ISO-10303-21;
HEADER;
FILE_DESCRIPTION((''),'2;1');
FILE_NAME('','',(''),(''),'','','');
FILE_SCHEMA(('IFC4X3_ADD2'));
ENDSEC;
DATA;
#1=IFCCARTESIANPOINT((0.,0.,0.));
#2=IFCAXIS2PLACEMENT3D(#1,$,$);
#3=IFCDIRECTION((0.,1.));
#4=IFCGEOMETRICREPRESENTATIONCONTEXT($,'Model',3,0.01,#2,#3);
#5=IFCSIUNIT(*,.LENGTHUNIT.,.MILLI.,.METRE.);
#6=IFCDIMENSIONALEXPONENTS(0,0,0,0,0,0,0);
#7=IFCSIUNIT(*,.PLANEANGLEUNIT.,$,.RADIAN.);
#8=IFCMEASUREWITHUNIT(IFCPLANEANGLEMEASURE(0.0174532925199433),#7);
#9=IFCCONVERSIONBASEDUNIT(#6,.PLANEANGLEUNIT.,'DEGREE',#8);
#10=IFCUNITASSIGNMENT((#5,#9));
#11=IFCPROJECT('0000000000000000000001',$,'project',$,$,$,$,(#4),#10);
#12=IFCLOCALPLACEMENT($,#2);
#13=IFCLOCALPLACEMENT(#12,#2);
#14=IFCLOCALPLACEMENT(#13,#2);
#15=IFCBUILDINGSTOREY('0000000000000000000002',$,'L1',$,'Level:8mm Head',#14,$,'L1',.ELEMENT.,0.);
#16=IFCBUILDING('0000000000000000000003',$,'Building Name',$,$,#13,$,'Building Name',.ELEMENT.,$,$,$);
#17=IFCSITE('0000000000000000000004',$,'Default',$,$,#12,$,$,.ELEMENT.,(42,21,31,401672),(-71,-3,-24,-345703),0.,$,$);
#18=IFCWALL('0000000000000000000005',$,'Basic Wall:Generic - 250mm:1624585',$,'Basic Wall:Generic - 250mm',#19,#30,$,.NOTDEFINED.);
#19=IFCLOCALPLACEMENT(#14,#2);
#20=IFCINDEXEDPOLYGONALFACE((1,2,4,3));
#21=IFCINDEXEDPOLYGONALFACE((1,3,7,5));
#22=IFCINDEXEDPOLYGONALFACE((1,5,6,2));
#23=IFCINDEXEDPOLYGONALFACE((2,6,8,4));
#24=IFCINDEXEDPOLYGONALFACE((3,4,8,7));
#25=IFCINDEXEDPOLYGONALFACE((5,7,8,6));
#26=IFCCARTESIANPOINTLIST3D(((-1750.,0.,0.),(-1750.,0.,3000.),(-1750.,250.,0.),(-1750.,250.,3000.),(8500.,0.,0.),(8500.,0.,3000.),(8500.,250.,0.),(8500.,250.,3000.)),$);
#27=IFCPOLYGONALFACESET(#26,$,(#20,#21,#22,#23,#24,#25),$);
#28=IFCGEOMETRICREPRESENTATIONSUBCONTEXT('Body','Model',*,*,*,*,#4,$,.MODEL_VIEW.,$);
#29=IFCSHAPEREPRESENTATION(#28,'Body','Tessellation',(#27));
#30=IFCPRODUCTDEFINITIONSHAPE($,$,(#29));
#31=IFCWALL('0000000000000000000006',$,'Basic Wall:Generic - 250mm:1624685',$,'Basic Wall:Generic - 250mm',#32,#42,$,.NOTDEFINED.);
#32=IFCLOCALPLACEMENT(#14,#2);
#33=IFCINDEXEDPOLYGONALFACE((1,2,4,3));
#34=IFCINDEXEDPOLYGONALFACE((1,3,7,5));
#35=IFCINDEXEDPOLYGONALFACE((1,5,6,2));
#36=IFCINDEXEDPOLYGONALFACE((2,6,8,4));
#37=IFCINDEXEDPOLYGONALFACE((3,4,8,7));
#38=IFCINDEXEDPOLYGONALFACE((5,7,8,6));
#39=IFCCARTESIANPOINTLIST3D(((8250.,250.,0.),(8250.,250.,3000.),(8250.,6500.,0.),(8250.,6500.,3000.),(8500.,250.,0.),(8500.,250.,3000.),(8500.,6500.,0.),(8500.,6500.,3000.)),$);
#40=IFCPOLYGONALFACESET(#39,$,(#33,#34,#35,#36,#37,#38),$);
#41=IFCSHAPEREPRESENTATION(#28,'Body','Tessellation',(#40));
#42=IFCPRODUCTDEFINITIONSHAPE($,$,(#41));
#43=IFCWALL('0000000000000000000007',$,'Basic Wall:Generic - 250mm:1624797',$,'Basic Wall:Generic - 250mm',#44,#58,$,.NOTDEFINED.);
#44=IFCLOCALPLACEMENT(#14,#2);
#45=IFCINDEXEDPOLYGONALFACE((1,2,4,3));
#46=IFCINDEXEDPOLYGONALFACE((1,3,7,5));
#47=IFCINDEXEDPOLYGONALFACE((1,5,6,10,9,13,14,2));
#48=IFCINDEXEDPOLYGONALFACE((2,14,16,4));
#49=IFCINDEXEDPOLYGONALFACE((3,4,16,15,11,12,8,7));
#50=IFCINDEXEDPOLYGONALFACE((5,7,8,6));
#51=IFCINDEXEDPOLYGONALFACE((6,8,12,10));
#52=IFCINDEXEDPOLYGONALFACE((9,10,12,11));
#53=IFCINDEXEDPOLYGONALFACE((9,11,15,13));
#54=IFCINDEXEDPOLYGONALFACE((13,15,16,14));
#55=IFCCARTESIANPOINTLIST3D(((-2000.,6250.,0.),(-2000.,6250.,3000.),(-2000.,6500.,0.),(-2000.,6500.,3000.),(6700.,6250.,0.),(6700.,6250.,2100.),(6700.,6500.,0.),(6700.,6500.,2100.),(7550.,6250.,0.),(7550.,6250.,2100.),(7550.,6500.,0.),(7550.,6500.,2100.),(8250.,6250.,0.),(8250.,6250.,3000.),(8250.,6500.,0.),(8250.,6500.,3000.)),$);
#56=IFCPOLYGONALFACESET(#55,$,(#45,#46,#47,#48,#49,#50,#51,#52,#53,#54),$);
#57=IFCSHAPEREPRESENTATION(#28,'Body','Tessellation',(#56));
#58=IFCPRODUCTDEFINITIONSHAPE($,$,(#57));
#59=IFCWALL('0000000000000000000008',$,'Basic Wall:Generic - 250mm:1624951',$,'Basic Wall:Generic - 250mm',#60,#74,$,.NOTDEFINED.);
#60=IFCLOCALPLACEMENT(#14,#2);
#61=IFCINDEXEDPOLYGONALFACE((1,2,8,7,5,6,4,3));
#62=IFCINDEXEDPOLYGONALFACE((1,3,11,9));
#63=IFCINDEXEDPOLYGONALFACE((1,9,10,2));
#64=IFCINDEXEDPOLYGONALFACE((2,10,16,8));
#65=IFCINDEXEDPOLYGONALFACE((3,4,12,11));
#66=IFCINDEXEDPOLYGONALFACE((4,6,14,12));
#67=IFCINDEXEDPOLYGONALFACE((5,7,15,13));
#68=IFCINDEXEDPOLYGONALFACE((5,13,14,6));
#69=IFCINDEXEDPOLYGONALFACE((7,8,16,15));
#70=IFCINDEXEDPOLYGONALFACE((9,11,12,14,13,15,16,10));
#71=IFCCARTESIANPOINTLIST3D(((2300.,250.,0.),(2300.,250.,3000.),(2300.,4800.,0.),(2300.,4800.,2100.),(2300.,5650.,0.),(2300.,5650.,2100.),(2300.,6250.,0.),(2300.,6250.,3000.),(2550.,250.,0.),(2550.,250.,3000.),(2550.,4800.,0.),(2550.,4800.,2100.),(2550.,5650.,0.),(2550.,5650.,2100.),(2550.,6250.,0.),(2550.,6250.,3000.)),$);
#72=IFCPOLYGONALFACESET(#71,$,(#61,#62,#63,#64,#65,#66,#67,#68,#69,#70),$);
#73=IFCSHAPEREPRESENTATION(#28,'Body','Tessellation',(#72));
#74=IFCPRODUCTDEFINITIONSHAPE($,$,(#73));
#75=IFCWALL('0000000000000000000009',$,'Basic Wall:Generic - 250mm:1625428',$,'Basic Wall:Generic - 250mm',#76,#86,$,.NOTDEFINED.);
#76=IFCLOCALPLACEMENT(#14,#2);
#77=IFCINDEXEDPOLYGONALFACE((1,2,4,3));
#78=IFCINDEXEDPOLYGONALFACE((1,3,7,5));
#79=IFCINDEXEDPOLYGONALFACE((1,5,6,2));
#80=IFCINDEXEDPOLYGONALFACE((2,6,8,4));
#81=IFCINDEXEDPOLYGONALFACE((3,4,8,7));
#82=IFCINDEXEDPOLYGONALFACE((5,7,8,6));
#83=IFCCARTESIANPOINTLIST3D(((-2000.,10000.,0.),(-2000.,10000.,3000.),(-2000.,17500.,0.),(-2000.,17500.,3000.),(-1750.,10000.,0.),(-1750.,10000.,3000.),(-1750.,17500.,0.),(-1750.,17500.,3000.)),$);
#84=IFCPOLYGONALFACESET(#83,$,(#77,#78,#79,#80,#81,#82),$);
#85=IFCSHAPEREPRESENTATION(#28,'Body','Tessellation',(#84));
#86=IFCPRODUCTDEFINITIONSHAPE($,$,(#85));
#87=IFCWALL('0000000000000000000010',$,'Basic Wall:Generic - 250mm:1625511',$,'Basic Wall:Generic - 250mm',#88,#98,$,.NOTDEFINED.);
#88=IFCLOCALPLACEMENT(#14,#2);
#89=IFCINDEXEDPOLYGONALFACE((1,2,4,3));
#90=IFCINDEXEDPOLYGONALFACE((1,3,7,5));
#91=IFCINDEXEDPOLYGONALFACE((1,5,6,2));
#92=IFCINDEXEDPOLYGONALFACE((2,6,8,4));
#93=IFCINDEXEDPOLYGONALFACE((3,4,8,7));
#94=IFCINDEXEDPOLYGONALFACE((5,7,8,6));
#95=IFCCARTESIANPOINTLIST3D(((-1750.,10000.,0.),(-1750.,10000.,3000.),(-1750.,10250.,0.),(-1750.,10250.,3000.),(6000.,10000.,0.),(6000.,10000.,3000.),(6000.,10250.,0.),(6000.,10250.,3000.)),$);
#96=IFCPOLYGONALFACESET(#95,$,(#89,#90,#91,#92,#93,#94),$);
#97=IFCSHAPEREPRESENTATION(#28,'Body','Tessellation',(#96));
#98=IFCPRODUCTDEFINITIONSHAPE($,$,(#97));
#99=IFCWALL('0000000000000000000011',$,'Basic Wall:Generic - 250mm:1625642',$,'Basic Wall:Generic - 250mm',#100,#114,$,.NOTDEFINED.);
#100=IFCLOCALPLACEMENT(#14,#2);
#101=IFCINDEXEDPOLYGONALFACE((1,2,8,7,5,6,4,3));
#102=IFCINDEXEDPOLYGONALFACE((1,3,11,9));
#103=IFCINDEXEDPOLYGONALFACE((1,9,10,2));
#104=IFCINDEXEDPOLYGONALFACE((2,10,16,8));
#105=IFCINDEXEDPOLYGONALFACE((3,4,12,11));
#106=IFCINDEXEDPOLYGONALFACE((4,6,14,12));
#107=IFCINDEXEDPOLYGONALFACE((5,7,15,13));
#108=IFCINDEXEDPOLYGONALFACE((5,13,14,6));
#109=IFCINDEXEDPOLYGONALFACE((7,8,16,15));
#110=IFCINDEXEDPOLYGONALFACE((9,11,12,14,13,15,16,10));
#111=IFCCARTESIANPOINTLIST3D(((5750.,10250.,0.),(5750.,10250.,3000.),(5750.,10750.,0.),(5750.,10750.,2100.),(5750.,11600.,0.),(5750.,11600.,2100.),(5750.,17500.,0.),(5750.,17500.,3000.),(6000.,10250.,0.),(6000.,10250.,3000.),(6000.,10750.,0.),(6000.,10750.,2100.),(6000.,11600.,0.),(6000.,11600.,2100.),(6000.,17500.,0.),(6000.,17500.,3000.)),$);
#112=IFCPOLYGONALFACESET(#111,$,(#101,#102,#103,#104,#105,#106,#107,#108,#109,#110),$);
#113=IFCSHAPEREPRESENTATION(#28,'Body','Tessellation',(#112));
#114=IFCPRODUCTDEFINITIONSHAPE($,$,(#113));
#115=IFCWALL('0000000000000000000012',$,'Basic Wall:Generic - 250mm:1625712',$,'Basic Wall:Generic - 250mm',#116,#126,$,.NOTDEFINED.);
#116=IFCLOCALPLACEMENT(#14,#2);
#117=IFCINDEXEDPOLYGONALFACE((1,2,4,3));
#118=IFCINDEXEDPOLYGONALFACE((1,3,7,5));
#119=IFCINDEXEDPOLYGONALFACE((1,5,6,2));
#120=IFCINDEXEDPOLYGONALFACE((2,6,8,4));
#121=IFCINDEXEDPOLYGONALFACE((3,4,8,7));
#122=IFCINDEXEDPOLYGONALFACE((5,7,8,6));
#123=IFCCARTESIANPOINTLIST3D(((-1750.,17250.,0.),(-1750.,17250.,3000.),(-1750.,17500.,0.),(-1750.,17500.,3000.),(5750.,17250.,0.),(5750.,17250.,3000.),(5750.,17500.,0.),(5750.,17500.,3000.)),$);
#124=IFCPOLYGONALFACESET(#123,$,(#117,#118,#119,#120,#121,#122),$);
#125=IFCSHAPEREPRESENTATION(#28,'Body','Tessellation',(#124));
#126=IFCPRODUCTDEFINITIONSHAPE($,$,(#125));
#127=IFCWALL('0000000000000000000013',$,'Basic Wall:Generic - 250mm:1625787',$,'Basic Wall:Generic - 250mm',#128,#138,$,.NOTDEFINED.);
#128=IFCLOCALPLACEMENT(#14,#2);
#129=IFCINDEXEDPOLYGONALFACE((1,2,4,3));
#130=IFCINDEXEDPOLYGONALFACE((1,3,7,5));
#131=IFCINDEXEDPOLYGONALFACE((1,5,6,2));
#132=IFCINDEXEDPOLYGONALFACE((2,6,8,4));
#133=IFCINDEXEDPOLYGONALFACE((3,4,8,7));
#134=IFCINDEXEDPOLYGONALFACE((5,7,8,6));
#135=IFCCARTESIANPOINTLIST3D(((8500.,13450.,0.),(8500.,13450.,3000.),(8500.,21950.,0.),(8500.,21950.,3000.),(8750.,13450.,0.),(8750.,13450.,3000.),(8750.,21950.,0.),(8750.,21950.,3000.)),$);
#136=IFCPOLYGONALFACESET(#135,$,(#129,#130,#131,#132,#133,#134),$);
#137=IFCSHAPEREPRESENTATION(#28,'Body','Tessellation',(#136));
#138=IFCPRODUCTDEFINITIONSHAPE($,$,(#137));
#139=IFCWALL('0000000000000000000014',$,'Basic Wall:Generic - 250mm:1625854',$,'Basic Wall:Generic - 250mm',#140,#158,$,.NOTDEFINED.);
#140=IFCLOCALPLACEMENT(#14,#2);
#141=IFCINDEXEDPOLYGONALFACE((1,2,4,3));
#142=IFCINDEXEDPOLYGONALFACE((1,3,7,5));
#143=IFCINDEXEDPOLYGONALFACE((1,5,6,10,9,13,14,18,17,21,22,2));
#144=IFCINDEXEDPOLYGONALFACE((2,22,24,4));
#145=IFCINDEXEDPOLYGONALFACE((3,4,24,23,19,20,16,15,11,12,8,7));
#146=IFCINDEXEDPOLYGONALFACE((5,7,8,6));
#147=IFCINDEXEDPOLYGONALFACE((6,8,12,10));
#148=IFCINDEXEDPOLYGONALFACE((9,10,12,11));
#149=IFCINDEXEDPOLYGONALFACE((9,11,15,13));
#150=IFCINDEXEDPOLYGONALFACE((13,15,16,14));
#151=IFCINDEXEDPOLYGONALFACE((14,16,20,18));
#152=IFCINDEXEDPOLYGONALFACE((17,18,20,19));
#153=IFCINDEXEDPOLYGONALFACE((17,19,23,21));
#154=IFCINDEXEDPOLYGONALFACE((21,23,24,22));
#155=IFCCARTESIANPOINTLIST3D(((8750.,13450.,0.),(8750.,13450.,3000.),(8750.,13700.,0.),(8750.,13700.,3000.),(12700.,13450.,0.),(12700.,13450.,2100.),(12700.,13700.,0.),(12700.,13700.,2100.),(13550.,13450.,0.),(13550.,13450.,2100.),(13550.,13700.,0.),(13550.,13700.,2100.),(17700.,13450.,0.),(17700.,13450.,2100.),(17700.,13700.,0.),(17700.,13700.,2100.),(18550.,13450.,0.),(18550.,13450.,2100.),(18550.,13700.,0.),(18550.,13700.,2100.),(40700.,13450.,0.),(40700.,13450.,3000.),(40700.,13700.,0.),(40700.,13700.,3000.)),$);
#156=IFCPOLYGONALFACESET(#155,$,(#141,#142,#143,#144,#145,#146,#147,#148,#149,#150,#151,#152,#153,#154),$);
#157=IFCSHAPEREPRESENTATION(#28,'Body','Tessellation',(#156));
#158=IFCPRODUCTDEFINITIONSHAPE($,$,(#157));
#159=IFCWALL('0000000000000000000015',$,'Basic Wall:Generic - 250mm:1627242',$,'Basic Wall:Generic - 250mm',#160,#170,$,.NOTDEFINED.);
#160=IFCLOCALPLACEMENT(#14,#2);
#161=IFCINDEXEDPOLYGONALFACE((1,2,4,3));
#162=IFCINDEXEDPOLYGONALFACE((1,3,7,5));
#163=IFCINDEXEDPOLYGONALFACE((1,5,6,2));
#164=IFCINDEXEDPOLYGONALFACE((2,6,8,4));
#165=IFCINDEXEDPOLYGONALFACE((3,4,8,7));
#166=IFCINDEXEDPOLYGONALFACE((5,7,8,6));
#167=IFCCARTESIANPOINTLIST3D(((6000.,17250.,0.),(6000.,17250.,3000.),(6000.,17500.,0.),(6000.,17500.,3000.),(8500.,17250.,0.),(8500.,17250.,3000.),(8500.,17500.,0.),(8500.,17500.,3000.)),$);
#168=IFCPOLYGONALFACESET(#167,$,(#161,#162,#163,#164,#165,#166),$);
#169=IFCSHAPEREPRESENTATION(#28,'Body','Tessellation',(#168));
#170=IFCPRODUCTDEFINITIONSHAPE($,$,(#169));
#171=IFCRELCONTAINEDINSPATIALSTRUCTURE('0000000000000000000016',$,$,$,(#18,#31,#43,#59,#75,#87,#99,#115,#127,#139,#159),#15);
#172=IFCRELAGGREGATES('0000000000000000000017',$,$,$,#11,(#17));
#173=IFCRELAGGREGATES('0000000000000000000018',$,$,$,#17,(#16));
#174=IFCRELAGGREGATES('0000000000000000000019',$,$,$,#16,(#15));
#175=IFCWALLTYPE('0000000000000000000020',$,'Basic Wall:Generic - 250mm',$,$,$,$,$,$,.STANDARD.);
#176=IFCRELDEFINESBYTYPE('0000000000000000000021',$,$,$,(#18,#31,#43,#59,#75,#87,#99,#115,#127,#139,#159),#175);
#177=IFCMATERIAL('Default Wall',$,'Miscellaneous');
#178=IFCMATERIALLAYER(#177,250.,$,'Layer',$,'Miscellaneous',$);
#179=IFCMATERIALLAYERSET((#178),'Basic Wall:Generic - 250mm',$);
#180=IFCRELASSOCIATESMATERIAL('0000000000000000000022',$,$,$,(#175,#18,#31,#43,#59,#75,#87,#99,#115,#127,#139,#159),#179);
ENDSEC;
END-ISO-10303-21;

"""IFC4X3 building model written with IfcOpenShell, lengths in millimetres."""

from ifc_helpers import new_model, entity, si_unit, converted_unit, direction, frame, frame_2d, origin, place, context, subcontext, project, spatial, rectangle, extrude, material, layer, layer_set, type_object, element, save


model = new_model("IFC4X3")

# Units and contexts
model_context = context("Model", 3, precision=0.01, world=origin(), true_north=direction((0.0, 1.0)))
body_context = subcontext(model_context, "Body", "Model", "MODEL_VIEW")
ifc_project = project(units=[si_unit("LENGTHUNIT", "METRE", prefix="MILLI"), converted_unit("PLANEANGLEUNIT", "DEGREE", entity("IfcPlaneAngleMeasure", 0.0174532925199433), si_unit("PLANEANGLEUNIT", "RADIAN"), dimensions=[0, 0, 0, 0, 0, 0, 0])], contexts=[model_context])

# Site, building, storey
site_placement = place(None, origin())
site = spatial("IfcSite", under=ifc_project, at=site_placement, Name="Default", CompositionType="ELEMENT", RefLatitude=(42, 21, 31, 401672), RefLongitude=(-71, -3, -24, -345703), RefElevation=0.0)
building_placement = place(site_placement, origin())
building = spatial("IfcBuilding", under=site, at=building_placement, Name="Building Name", LongName="Building Name", CompositionType="ELEMENT")
storey_placement = place(building_placement, origin())
storey = spatial("IfcBuildingStorey", under=building, at=storey_placement, Name="L1", ObjectType="Level:8mm Head", LongName="L1", CompositionType="ELEMENT", Elevation=0.0)

# Walls
ifc_material = material(Name="Default Wall", Category="Miscellaneous")
ifc_layer = layer(ifc_material, 250.0, Name="Layer", Category="Miscellaneous")
ifc_layer_set = layer_set([ifc_layer], Name="Basic Wall:Generic - 250mm")
wall_type = type_object("IfcWallType", Name="Basic Wall:Generic - 250mm", PredefinedType="STANDARD", material=ifc_layer_set)
wall_1_placement = place(storey_placement, frame((-1750.0, 125.0, 0.0)))
element("IfcWall", 1, at=wall_1_placement, inside=storey, type_object=wall_type, material=ifc_layer_set, Name="Basic Wall:Generic - 250mm:1624585", ObjectType="Basic Wall:Generic - 250mm", PredefinedType="NOTDEFINED", context=body_context, shape_type="SweptSolid", body=[
    extrude(rectangle(XDim=10250.0, YDim=250.0, at=frame_2d((5125.0, 0.0), x_axis=(-1.0, 0.0))), origin(), (0.0, 0.0, 1.0), 3000.0),
])
wall_2_placement = place(storey_placement, frame((8375.0, 250.0, 0.0), z_axis=(0.0, 0.0, 1.0), x_axis=(0.0, 1.0, 0.0)))
element("IfcWall", 2, at=wall_2_placement, inside=storey, type_object=wall_type, material=ifc_layer_set, Name="Basic Wall:Generic - 250mm:1624685", ObjectType="Basic Wall:Generic - 250mm", PredefinedType="NOTDEFINED", context=body_context, shape_type="SweptSolid", body=[
    extrude(rectangle(XDim=6250.0, YDim=250.0, at=frame_2d((3125.0, 0.0), x_axis=(-1.0, 0.0))), origin(), (0.0, 0.0, 1.0), 3000.0),
])

# Walls, openings
wall_3_placement = place(storey_placement, frame((8250.0, 6375.0, 0.0), z_axis=(0.0, 0.0, 1.0), x_axis=(-1.0, 0.0, 0.0)))
wall_3 = element("IfcWall", 3, at=wall_3_placement, inside=storey, type_object=wall_type, material=ifc_layer_set, Name="Basic Wall:Generic - 250mm:1624797", ObjectType="Basic Wall:Generic - 250mm", PredefinedType="NOTDEFINED", context=body_context, shape_type="SweptSolid", body=[
    extrude(rectangle(XDim=10250.0, YDim=250.0, at=frame_2d((5125.0, 0.0), x_axis=(1.0, 0.0))), origin(), (0.0, 0.0, 1.0), 3000.0),
])
opening_1_placement = place(wall_3_placement, frame((700.0, -125.0, 0.0)))
element("IfcOpeningElement", 4, at=opening_1_placement, cuts=wall_3, PredefinedType="OPENING", context=body_context, shape_type="SweptSolid", body=[
    extrude(rectangle(XDim=2100.0, YDim=850.0, at=frame_2d((1050.0, 425.0), x_axis=(1.0, 0.0))), frame((0.0, 0.0, 0.0), z_axis=(0.0, 1.0, 0.0), x_axis=(0.0, 0.0, 1.0)), (0.0, 0.0, 1.0), 250.0),
])
wall_4_placement = place(storey_placement, frame((2425.0, 6250.0, 0.0), z_axis=(0.0, 0.0, 1.0), x_axis=(0.0, -1.0, 0.0)))
wall_4 = element("IfcWall", 5, at=wall_4_placement, inside=storey, type_object=wall_type, material=ifc_layer_set, Name="Basic Wall:Generic - 250mm:1624951", ObjectType="Basic Wall:Generic - 250mm", PredefinedType="NOTDEFINED", context=body_context, shape_type="SweptSolid", body=[
    extrude(rectangle(XDim=6000.0, YDim=250.0, at=frame_2d((3000.0, 0.0), x_axis=(1.0, 0.0))), origin(), (0.0, 0.0, 1.0), 3000.0),
])
opening_2_placement = place(wall_4_placement, frame((1450.0, 125.0, 0.0)))
element("IfcOpeningElement", 6, at=opening_2_placement, cuts=wall_4, PredefinedType="OPENING", context=body_context, shape_type="SweptSolid", body=[
    extrude(rectangle(XDim=2100.0, YDim=850.0, at=frame_2d((1050.0, 425.0), x_axis=(1.0, 0.0))), frame((0.0, 0.0, 0.0), z_axis=(0.0, -1.0, 0.0), x_axis=(0.0, 0.0, 1.0)), (0.0, 0.0, 1.0), 250.0),
])

# Walls
wall_5_placement = place(storey_placement, frame((-1875.0, 17500.0, 0.0), z_axis=(0.0, 0.0, 1.0), x_axis=(0.0, -1.0, 0.0)))
element("IfcWall", 7, at=wall_5_placement, inside=storey, type_object=wall_type, material=ifc_layer_set, Name="Basic Wall:Generic - 250mm:1625428", ObjectType="Basic Wall:Generic - 250mm", PredefinedType="NOTDEFINED", context=body_context, shape_type="SweptSolid", body=[
    extrude(rectangle(XDim=7500.0, YDim=250.0, at=frame_2d((3750.0, 0.0), x_axis=(-1.0, 0.0))), origin(), (0.0, 0.0, 1.0), 3000.0),
])
wall_6_placement = place(storey_placement, frame((-1750.0, 10125.0, 0.0)))
element("IfcWall", 8, at=wall_6_placement, inside=storey, type_object=wall_type, material=ifc_layer_set, Name="Basic Wall:Generic - 250mm:1625511", ObjectType="Basic Wall:Generic - 250mm", PredefinedType="NOTDEFINED", context=body_context, shape_type="SweptSolid", body=[
    extrude(rectangle(XDim=7750.0, YDim=250.0, at=frame_2d((3875.0, 0.0), x_axis=(-1.0, 0.0))), origin(), (0.0, 0.0, 1.0), 3000.0),
])

# Wall, opening
wall_7_placement = place(storey_placement, frame((5875.0, 10250.0, 0.0), z_axis=(0.0, 0.0, 1.0), x_axis=(0.0, 1.0, 0.0)))
wall_7 = element("IfcWall", 9, at=wall_7_placement, inside=storey, type_object=wall_type, material=ifc_layer_set, Name="Basic Wall:Generic - 250mm:1625642", ObjectType="Basic Wall:Generic - 250mm", PredefinedType="NOTDEFINED", context=body_context, shape_type="SweptSolid", body=[
    extrude(rectangle(XDim=7250.0, YDim=250.0, at=frame_2d((3625.0, 0.0), x_axis=(1.0, 0.0))), origin(), (0.0, 0.0, 1.0), 3000.0),
])
opening_3_placement = place(wall_7_placement, frame((500.0, -125.0, 0.0)))
element("IfcOpeningElement", 10, at=opening_3_placement, cuts=wall_7, PredefinedType="OPENING", context=body_context, shape_type="SweptSolid", body=[
    extrude(rectangle(XDim=2100.0, YDim=850.0, at=frame_2d((1050.0, 425.0), x_axis=(1.0, 0.0))), frame((0.0, 0.0, 0.0), z_axis=(0.0, 1.0, 0.0), x_axis=(0.0, 0.0, 1.0)), (0.0, 0.0, 1.0), 250.0),
])

# Walls
wall_8_placement = place(storey_placement, frame((5750.0, 17375.0, 0.0), z_axis=(0.0, 0.0, 1.0), x_axis=(-1.0, 0.0, 0.0)))
element("IfcWall", 11, at=wall_8_placement, inside=storey, type_object=wall_type, material=ifc_layer_set, Name="Basic Wall:Generic - 250mm:1625712", ObjectType="Basic Wall:Generic - 250mm", PredefinedType="NOTDEFINED", context=body_context, shape_type="SweptSolid", body=[
    extrude(rectangle(XDim=7500.0, YDim=250.0, at=frame_2d((3750.0, 0.0), x_axis=(-1.0, 0.0))), origin(), (0.0, 0.0, 1.0), 3000.0),
])
wall_9_placement = place(storey_placement, frame((8625.0, 21950.0, 0.0), z_axis=(0.0, 0.0, 1.0), x_axis=(0.0, -1.0, 0.0)))
element("IfcWall", 12, at=wall_9_placement, inside=storey, type_object=wall_type, material=ifc_layer_set, Name="Basic Wall:Generic - 250mm:1625787", ObjectType="Basic Wall:Generic - 250mm", PredefinedType="NOTDEFINED", context=body_context, shape_type="SweptSolid", body=[
    extrude(rectangle(XDim=8500.0, YDim=250.0, at=frame_2d((4250.0, 0.0), x_axis=(-1.0, 0.0))), origin(), (0.0, 0.0, 1.0), 3000.0),
])

# Wall, openings
wall_10_placement = place(storey_placement, frame((8750.0, 13575.0, 0.0)))
wall_10 = element("IfcWall", 13, at=wall_10_placement, inside=storey, type_object=wall_type, material=ifc_layer_set, Name="Basic Wall:Generic - 250mm:1625854", ObjectType="Basic Wall:Generic - 250mm", PredefinedType="NOTDEFINED", context=body_context, shape_type="SweptSolid", body=[
    extrude(rectangle(XDim=31950.0, YDim=250.0, at=frame_2d((15975.0, 0.0), x_axis=(1.0, 0.0))), origin(), (0.0, 0.0, 1.0), 3000.0),
])
opening_4_placement = place(wall_10_placement, frame((3950.0, -125.0, 0.0)))
element("IfcOpeningElement", 14, at=opening_4_placement, cuts=wall_10, PredefinedType="OPENING", context=body_context, shape_type="SweptSolid", body=[
    extrude(rectangle(XDim=2100.0, YDim=850.0, at=frame_2d((1050.0, 425.0), x_axis=(1.0, 0.0))), frame((0.0, 0.0, 0.0), z_axis=(0.0, 1.0, 0.0), x_axis=(0.0, 0.0, 1.0)), (0.0, 0.0, 1.0), 250.0),
])
opening_5_placement = place(wall_10_placement, frame((8950.0, -125.0, 0.0)))
element("IfcOpeningElement", 15, at=opening_5_placement, cuts=wall_10, PredefinedType="OPENING", context=body_context, shape_type="SweptSolid", body=[
    extrude(rectangle(XDim=2100.0, YDim=850.0, at=frame_2d((1050.0, 425.0), x_axis=(1.0, 0.0))), frame((0.0, 0.0, 0.0), z_axis=(0.0, 1.0, 0.0), x_axis=(0.0, 0.0, 1.0)), (0.0, 0.0, 1.0), 250.0),
])

# Wall
wall_11_placement = place(storey_placement, frame((6000.0, 17375.0, 0.0)))
element("IfcWall", 16, at=wall_11_placement, inside=storey, type_object=wall_type, material=ifc_layer_set, Name="Basic Wall:Generic - 250mm:1627242", ObjectType="Basic Wall:Generic - 250mm", PredefinedType="NOTDEFINED", context=body_context, shape_type="SweptSolid", body=[
    extrude(rectangle(XDim=2500.0, YDim=250.0, at=frame_2d((1250.0, 0.0), x_axis=(-1.0, 0.0))), origin(), (0.0, 0.0, 1.0), 3000.0),
])

save(model, "model.ifc")
